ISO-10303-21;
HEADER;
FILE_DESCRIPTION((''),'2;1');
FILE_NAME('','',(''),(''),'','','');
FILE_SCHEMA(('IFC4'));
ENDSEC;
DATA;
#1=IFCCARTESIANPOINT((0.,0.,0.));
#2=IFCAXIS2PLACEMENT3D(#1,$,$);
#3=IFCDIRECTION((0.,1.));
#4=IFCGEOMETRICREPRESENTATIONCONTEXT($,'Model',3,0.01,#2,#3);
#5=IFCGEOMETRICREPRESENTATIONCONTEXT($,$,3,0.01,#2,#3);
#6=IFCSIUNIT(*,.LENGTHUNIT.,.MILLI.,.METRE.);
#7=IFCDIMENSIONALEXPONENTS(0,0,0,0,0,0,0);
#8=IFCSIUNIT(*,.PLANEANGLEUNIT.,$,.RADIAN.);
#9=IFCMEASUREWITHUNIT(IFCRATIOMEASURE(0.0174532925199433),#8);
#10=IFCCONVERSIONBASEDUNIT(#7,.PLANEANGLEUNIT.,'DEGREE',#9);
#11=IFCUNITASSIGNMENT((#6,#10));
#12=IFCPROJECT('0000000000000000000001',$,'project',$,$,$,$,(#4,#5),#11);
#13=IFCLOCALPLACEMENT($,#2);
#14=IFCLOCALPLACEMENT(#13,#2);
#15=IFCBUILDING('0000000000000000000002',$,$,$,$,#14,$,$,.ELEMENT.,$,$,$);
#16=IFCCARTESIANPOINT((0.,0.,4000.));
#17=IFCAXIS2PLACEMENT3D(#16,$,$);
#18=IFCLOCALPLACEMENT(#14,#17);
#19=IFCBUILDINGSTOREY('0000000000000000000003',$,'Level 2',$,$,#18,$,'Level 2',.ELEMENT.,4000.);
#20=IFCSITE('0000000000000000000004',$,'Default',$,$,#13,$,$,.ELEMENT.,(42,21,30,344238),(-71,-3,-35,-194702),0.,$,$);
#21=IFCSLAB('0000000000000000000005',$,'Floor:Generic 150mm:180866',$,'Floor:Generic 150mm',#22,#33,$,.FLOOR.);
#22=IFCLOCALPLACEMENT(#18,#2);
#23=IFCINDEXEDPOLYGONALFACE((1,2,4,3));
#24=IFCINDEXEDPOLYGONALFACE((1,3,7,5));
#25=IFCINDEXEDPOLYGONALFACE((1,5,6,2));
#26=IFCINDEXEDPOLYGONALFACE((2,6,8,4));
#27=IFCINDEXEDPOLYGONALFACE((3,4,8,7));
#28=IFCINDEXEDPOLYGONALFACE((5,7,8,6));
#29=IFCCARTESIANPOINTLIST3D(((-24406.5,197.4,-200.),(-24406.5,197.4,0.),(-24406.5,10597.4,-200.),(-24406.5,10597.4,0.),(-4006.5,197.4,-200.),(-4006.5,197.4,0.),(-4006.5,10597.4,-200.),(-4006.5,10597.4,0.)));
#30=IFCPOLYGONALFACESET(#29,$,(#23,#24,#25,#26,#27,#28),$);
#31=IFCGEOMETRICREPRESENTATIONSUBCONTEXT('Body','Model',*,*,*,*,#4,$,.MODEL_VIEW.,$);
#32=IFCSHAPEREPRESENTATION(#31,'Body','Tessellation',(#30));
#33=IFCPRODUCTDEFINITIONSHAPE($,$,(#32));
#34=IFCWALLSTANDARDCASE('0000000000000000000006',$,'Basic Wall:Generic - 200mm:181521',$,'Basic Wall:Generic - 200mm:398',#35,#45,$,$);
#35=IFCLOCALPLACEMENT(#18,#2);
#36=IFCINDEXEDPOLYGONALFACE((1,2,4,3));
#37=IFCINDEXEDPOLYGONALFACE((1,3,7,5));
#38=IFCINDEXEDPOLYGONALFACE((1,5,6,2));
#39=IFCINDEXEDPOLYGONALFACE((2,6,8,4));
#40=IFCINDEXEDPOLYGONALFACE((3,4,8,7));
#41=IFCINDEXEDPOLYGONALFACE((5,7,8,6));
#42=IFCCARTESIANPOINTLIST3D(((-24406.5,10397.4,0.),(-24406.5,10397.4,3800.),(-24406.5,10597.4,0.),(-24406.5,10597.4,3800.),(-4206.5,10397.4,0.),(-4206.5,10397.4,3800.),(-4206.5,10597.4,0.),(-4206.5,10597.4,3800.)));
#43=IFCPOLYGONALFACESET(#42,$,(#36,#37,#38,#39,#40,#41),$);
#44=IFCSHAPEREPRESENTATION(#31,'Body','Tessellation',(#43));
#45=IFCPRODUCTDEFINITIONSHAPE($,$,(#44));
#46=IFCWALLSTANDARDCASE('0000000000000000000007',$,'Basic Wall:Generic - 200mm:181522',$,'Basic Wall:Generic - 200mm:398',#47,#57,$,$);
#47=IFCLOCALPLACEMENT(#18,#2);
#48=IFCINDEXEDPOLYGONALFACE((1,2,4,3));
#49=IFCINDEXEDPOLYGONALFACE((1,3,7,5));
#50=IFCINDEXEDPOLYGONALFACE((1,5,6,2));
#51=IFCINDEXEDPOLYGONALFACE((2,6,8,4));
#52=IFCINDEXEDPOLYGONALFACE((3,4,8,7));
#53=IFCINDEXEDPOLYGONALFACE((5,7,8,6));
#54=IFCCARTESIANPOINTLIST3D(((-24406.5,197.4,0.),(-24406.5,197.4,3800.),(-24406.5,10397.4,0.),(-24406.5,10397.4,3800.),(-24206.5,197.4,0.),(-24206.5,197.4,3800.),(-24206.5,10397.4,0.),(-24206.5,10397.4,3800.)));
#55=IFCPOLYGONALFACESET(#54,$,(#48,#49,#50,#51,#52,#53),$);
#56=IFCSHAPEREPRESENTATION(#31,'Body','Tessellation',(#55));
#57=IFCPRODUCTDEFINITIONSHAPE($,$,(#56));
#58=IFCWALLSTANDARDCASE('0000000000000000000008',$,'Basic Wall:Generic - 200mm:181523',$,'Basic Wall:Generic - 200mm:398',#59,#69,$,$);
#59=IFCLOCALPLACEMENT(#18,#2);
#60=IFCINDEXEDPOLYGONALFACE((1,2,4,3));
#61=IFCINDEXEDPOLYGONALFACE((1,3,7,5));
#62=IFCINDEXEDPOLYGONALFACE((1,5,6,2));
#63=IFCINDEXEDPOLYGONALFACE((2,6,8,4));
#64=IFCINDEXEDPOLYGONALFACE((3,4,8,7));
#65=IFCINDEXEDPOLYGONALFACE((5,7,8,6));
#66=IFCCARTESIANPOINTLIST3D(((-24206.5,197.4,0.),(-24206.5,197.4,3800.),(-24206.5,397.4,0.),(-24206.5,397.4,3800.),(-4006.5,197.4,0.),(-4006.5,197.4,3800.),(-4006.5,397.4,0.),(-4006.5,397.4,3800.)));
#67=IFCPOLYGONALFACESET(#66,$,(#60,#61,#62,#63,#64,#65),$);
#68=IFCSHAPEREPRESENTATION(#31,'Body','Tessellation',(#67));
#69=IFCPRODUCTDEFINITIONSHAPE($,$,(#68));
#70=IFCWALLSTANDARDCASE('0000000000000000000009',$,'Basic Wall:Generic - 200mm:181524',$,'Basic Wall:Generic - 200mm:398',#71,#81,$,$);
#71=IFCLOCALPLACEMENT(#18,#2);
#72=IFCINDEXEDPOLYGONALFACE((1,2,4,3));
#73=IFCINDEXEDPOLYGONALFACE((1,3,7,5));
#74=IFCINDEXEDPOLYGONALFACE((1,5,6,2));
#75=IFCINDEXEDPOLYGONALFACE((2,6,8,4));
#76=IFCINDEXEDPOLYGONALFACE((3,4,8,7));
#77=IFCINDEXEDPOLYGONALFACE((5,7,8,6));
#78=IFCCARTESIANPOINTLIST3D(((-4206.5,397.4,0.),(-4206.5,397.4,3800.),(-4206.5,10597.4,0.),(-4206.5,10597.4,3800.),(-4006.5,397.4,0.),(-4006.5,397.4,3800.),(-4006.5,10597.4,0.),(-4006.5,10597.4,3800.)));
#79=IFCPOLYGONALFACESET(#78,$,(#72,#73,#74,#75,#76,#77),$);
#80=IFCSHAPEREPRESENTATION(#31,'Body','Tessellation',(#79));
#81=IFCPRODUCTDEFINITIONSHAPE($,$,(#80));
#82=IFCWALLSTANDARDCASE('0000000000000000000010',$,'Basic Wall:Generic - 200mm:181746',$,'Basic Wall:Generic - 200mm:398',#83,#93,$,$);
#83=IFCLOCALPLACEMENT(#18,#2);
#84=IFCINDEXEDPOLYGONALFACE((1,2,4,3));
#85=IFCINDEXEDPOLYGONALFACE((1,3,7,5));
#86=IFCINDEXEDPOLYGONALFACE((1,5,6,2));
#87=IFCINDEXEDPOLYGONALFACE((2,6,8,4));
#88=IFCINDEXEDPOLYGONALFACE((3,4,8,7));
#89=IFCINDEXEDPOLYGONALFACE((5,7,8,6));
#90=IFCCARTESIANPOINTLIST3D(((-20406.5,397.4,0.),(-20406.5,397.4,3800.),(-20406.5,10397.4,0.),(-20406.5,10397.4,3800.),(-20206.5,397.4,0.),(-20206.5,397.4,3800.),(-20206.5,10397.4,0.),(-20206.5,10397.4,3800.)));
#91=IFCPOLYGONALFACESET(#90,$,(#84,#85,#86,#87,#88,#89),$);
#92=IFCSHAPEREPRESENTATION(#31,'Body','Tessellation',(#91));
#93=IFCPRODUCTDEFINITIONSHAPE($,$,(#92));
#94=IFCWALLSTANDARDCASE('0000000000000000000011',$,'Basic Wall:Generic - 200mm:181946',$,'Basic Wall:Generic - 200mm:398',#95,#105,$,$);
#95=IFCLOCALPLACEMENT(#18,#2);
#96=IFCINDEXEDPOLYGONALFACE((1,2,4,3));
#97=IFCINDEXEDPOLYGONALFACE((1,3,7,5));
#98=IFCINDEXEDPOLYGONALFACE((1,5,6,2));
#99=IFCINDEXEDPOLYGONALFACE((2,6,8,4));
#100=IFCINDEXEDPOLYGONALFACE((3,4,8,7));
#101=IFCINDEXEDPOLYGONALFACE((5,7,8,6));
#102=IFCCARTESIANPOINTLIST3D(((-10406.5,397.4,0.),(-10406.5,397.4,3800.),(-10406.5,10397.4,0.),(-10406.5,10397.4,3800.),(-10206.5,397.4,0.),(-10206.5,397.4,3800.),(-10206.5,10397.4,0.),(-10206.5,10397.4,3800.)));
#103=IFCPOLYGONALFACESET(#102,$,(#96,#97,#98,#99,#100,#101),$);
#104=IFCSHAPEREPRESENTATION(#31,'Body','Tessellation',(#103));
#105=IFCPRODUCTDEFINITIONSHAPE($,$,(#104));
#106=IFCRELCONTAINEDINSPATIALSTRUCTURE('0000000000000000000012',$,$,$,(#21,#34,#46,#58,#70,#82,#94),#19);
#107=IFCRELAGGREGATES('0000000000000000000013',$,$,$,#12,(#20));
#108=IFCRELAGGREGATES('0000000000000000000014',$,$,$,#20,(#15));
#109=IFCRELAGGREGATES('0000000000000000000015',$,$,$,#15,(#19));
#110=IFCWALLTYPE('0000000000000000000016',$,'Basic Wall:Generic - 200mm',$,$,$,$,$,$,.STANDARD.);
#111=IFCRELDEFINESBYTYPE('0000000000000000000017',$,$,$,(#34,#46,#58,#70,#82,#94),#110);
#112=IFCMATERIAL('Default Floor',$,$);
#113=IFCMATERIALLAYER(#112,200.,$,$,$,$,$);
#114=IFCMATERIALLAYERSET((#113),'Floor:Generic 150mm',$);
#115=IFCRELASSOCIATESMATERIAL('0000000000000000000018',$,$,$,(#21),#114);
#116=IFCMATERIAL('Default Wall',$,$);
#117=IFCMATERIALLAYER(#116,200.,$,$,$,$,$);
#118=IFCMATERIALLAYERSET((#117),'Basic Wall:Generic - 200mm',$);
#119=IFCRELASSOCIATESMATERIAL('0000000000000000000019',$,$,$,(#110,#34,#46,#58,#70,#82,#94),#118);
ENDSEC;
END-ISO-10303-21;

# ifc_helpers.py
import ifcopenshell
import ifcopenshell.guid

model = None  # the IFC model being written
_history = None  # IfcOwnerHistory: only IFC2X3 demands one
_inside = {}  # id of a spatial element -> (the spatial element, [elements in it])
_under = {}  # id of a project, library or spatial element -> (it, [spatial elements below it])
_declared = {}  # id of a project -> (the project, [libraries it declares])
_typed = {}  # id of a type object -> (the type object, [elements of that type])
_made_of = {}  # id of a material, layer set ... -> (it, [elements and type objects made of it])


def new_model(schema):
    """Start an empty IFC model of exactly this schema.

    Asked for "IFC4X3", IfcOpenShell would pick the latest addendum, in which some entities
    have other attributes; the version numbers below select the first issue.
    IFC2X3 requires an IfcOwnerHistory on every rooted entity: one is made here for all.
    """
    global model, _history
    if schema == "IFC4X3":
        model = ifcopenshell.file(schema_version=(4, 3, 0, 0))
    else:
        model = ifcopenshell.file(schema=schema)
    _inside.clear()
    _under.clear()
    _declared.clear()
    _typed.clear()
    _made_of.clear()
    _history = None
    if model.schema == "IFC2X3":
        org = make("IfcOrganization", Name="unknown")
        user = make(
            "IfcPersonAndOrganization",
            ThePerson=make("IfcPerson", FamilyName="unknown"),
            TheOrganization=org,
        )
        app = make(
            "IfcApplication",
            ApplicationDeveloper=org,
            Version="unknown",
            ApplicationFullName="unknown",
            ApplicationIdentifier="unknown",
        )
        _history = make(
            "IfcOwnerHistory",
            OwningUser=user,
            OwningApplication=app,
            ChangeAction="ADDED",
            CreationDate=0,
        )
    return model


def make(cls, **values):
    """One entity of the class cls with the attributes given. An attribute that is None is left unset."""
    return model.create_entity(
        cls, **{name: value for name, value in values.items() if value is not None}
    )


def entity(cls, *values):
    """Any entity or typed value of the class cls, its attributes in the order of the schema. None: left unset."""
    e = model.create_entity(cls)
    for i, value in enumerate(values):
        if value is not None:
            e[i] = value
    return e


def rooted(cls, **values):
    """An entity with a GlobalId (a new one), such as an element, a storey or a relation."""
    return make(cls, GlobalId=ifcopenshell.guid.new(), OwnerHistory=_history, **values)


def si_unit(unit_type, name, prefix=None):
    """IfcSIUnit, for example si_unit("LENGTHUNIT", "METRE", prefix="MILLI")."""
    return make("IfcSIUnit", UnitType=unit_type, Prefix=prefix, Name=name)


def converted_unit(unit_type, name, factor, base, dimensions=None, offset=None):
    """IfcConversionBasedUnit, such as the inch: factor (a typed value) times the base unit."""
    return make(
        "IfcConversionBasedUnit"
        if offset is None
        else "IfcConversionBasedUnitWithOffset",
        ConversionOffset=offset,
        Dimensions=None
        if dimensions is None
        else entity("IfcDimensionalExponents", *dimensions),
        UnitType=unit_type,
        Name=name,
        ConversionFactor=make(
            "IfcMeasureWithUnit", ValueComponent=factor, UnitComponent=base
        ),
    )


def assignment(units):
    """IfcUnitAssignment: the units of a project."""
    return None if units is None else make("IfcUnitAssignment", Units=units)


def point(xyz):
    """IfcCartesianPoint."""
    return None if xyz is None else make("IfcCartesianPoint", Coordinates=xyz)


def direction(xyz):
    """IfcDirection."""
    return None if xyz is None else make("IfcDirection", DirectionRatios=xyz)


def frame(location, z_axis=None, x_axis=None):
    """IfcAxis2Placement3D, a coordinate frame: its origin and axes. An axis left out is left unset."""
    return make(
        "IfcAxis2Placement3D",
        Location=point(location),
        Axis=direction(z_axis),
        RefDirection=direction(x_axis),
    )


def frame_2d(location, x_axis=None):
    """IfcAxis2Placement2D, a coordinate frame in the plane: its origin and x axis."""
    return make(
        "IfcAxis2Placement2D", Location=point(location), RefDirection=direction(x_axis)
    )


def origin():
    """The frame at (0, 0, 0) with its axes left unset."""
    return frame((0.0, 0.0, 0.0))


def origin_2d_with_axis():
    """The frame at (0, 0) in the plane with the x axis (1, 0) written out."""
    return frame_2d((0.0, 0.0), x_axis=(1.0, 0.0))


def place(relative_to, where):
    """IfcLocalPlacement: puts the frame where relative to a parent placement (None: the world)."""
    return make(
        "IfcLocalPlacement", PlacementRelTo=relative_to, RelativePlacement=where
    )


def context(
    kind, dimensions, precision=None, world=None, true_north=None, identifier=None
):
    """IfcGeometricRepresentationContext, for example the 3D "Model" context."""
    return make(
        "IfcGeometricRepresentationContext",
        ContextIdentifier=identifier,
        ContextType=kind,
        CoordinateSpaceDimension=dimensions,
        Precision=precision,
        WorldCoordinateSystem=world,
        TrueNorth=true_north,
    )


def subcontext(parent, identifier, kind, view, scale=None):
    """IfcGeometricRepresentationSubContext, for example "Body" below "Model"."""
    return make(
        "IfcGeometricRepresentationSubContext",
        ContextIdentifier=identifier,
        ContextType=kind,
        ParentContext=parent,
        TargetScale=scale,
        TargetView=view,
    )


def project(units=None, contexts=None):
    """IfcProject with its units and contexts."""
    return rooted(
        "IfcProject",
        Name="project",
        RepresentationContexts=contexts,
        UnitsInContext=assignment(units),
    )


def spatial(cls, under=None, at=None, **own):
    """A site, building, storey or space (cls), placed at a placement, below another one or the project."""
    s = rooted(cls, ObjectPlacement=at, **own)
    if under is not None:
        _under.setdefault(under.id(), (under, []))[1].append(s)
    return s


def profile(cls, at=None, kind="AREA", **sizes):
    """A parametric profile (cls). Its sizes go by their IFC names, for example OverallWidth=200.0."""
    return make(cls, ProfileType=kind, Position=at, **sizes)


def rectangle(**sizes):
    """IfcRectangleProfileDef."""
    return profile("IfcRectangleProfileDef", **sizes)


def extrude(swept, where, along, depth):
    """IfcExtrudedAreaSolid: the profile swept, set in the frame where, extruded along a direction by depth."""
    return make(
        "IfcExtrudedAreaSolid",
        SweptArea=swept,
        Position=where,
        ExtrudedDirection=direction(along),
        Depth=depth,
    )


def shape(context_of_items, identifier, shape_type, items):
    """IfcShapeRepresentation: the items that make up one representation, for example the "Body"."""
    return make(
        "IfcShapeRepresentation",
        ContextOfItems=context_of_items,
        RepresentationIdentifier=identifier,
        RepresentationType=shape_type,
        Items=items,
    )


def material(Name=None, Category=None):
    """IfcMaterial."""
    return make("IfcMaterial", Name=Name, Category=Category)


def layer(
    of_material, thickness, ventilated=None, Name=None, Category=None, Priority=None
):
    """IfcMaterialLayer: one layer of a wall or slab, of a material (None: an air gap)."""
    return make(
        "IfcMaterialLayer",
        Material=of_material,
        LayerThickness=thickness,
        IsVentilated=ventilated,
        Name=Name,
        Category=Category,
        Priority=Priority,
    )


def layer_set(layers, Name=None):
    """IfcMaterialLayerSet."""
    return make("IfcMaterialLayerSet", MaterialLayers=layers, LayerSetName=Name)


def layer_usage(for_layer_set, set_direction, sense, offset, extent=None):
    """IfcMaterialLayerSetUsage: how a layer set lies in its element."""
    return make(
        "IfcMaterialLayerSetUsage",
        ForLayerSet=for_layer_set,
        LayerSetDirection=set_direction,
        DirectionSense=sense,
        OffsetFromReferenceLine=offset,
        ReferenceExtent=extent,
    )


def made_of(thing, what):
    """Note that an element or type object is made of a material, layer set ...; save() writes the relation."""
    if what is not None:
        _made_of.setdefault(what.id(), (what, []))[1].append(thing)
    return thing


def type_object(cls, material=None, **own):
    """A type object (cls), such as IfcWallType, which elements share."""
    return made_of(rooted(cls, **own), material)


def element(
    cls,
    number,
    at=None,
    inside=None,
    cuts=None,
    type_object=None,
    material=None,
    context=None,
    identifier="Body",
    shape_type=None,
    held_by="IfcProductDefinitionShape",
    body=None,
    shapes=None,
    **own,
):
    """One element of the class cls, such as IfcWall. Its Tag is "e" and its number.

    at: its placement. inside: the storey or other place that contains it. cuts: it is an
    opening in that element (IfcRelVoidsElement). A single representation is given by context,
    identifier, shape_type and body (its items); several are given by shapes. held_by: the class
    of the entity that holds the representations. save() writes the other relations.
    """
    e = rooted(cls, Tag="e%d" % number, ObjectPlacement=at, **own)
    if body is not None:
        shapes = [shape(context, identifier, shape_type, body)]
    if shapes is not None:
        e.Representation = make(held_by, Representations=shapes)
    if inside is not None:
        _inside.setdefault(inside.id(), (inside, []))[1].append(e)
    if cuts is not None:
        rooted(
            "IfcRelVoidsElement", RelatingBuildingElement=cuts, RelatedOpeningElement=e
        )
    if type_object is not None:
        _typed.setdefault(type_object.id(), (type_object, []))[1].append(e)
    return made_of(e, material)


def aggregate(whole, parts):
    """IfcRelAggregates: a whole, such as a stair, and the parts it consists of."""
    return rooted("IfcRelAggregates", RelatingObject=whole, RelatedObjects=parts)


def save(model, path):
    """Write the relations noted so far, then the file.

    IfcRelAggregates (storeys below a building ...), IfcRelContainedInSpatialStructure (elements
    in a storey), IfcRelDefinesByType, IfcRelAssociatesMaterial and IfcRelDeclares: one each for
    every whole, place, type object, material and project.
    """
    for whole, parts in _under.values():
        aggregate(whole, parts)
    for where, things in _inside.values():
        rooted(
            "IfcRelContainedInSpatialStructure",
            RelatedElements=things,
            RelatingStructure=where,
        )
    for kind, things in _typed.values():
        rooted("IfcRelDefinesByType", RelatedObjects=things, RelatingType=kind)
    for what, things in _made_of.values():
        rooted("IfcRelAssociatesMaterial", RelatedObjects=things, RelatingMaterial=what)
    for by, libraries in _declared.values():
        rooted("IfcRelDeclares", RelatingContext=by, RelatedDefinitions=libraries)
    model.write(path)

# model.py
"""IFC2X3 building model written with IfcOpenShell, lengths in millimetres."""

from ifc_helpers import new_model, entity, si_unit, converted_unit, direction, frame, frame_2d, origin, origin_2d_with_axis, place, context, subcontext, project, spatial, rectangle, extrude, material, layer, layer_set, layer_usage, type_object, element, save


model = new_model("IFC2X3")

# Units and contexts
model_context = context("Model", 3, precision=0.01, world=origin(), true_north=direction((0.0, 1.0)))
context_of_model = context(None, 3, precision=0.01, world=origin(), true_north=direction((0.0, 1.0)))
body_context = subcontext(model_context, "Body", "Model", "MODEL_VIEW")
ifc_project = project(units=[si_unit("LENGTHUNIT", "METRE", prefix="MILLI"), converted_unit("PLANEANGLEUNIT", "DEGREE", entity("IfcRatioMeasure", 0.0174532925199433), si_unit("PLANEANGLEUNIT", "RADIAN"), dimensions=[0, 0, 0, 0, 0, 0, 0])], contexts=[model_context, context_of_model])

# Site, building, storey
site_placement = place(None, origin())
site = spatial("IfcSite", under=ifc_project, at=site_placement, Name="Default", CompositionType="ELEMENT", RefLatitude=(42, 21, 30, 344238), RefLongitude=(-71, -3, -35, -194702), RefElevation=0.0)
building_placement = place(site_placement, origin())
building = spatial("IfcBuilding", under=site, at=building_placement, CompositionType="ELEMENT")
storey_placement = place(building_placement, frame((0.0, 0.0, 4000.0)))
storey = spatial("IfcBuildingStorey", under=building, at=storey_placement, Name="Level 2", LongName="Level 2", CompositionType="ELEMENT", Elevation=4000.0)

# Slab
ifc_material_1 = material(Name="Default Floor")
ifc_layer_1 = layer(ifc_material_1, 200.0)
ifc_layer_set_1 = layer_set([ifc_layer_1], Name="Floor:Generic 150mm")
ifc_layer_usage_1 = layer_usage(ifc_layer_set_1, "AXIS3", "POSITIVE", 0.0)
slab_placement = place(storey_placement, origin())
element("IfcSlab", 1, at=slab_placement, inside=storey, material=ifc_layer_usage_1, Name="Floor:Generic 150mm:180866", ObjectType="Floor:Generic 150mm", PredefinedType="FLOOR", context=body_context, shape_type="SweptSolid", body=[
    extrude(rectangle(XDim=10400.0, YDim=20400.0, at=origin_2d_with_axis()), frame((-14206.5, 5397.4, 0.0), z_axis=(0.0, 0.0, -1.0), x_axis=(0.0, 1.0, 0.0)), (0.0, 0.0, 1.0), 200.0),
])

# Walls
ifc_material_2 = material(Name="Default Wall")
ifc_layer_2 = layer(ifc_material_2, 200.0)
ifc_layer_set_2 = layer_set([ifc_layer_2], Name="Basic Wall:Generic - 200mm")
ifc_layer_usage_2 = layer_usage(ifc_layer_set_2, "AXIS2", "NEGATIVE", 100.0)
wall_type = type_object("IfcWallType", Name="Basic Wall:Generic - 200mm", PredefinedType="STANDARD", material=ifc_layer_set_2)
wall_1_placement = place(storey_placement, frame((-24406.5, 10497.4, 0.0)))
element("IfcWallStandardCase", 2, at=wall_1_placement, inside=storey, type_object=wall_type, material=ifc_layer_usage_2, Name="Basic Wall:Generic - 200mm:181521", ObjectType="Basic Wall:Generic - 200mm:398", context=body_context, shape_type="SweptSolid", body=[
    extrude(rectangle(XDim=20200.0, YDim=200.0, at=frame_2d((10100.0, 0.0), x_axis=(-1.0, 0.0))), origin(), (0.0, 0.0, 1.0), 3800.0),
])
ifc_layer_usage_3 = layer_usage(ifc_layer_set_2, "AXIS2", "NEGATIVE", 100.0)
wall_2_placement = place(storey_placement, frame((-24306.5, 197.4, 0.0), z_axis=(0.0, 0.0, 1.0), x_axis=(0.0, 1.0, 0.0)))
element("IfcWallStandardCase", 3, at=wall_2_placement, inside=storey, type_object=wall_type, material=ifc_layer_usage_3, Name="Basic Wall:Generic - 200mm:181522", ObjectType="Basic Wall:Generic - 200mm:398", context=body_context, shape_type="SweptSolid", body=[
    extrude(rectangle(XDim=10200.0, YDim=200.0, at=frame_2d((5100.0, 0.0), x_axis=(-1.0, 0.0))), origin(), (0.0, 0.0, 1.0), 3800.0),
])
ifc_layer_usage_4 = layer_usage(ifc_layer_set_2, "AXIS2", "NEGATIVE", 100.0)
wall_3_placement = place(storey_placement, frame((-4006.5, 297.4, 0.0), z_axis=(0.0, 0.0, 1.0), x_axis=(-1.0, 0.0, 0.0)))
element("IfcWallStandardCase", 4, at=wall_3_placement, inside=storey, type_object=wall_type, material=ifc_layer_usage_4, Name="Basic Wall:Generic - 200mm:181523", ObjectType="Basic Wall:Generic - 200mm:398", context=body_context, shape_type="SweptSolid", body=[
    extrude(rectangle(XDim=20200.0, YDim=200.0, at=frame_2d((10100.0, 0.0), x_axis=(-1.0, 0.0))), origin(), (0.0, 0.0, 1.0), 3800.0),
])
ifc_layer_usage_5 = layer_usage(ifc_layer_set_2, "AXIS2", "NEGATIVE", 100.0)
wall_4_placement = place(storey_placement, frame((-4106.5, 10597.4, 0.0), z_axis=(0.0, 0.0, 1.0), x_axis=(0.0, -1.0, 0.0)))
element("IfcWallStandardCase", 5, at=wall_4_placement, inside=storey, type_object=wall_type, material=ifc_layer_usage_5, Name="Basic Wall:Generic - 200mm:181524", ObjectType="Basic Wall:Generic - 200mm:398", context=body_context, shape_type="SweptSolid", body=[
    extrude(rectangle(XDim=10200.0, YDim=200.0, at=frame_2d((5100.0, 0.0), x_axis=(-1.0, 0.0))), origin(), (0.0, 0.0, 1.0), 3800.0),
])
ifc_layer_usage_6 = layer_usage(ifc_layer_set_2, "AXIS2", "NEGATIVE", 100.0)
wall_5_placement = place(storey_placement, frame((-20306.5, 10397.4, 0.0), z_axis=(0.0, 0.0, 1.0), x_axis=(0.0, -1.0, 0.0)))
element("IfcWallStandardCase", 6, at=wall_5_placement, inside=storey, type_object=wall_type, material=ifc_layer_usage_6, Name="Basic Wall:Generic - 200mm:181746", ObjectType="Basic Wall:Generic - 200mm:398", context=body_context, shape_type="SweptSolid", body=[
    extrude(rectangle(XDim=10000.0, YDim=200.0, at=frame_2d((5000.0, 0.0), x_axis=(-1.0, 0.0))), origin(), (0.0, 0.0, 1.0), 3800.0),
])
ifc_layer_usage_7 = layer_usage(ifc_layer_set_2, "AXIS2", "NEGATIVE", 100.0)
wall_6_placement = place(storey_placement, frame((-10306.5, 10397.4, 0.0), z_axis=(0.0, 0.0, 1.0), x_axis=(0.0, -1.0, 0.0)))
element("IfcWallStandardCase", 7, at=wall_6_placement, inside=storey, type_object=wall_type, material=ifc_layer_usage_7, Name="Basic Wall:Generic - 200mm:181946", ObjectType="Basic Wall:Generic - 200mm:398", context=body_context, shape_type="SweptSolid", body=[
    extrude(rectangle(XDim=10000.0, YDim=200.0, at=frame_2d((5000.0, 0.0), x_axis=(-1.0, 0.0))), origin(), (0.0, 0.0, 1.0), 3800.0),
])

save(model, "model.ifc")
